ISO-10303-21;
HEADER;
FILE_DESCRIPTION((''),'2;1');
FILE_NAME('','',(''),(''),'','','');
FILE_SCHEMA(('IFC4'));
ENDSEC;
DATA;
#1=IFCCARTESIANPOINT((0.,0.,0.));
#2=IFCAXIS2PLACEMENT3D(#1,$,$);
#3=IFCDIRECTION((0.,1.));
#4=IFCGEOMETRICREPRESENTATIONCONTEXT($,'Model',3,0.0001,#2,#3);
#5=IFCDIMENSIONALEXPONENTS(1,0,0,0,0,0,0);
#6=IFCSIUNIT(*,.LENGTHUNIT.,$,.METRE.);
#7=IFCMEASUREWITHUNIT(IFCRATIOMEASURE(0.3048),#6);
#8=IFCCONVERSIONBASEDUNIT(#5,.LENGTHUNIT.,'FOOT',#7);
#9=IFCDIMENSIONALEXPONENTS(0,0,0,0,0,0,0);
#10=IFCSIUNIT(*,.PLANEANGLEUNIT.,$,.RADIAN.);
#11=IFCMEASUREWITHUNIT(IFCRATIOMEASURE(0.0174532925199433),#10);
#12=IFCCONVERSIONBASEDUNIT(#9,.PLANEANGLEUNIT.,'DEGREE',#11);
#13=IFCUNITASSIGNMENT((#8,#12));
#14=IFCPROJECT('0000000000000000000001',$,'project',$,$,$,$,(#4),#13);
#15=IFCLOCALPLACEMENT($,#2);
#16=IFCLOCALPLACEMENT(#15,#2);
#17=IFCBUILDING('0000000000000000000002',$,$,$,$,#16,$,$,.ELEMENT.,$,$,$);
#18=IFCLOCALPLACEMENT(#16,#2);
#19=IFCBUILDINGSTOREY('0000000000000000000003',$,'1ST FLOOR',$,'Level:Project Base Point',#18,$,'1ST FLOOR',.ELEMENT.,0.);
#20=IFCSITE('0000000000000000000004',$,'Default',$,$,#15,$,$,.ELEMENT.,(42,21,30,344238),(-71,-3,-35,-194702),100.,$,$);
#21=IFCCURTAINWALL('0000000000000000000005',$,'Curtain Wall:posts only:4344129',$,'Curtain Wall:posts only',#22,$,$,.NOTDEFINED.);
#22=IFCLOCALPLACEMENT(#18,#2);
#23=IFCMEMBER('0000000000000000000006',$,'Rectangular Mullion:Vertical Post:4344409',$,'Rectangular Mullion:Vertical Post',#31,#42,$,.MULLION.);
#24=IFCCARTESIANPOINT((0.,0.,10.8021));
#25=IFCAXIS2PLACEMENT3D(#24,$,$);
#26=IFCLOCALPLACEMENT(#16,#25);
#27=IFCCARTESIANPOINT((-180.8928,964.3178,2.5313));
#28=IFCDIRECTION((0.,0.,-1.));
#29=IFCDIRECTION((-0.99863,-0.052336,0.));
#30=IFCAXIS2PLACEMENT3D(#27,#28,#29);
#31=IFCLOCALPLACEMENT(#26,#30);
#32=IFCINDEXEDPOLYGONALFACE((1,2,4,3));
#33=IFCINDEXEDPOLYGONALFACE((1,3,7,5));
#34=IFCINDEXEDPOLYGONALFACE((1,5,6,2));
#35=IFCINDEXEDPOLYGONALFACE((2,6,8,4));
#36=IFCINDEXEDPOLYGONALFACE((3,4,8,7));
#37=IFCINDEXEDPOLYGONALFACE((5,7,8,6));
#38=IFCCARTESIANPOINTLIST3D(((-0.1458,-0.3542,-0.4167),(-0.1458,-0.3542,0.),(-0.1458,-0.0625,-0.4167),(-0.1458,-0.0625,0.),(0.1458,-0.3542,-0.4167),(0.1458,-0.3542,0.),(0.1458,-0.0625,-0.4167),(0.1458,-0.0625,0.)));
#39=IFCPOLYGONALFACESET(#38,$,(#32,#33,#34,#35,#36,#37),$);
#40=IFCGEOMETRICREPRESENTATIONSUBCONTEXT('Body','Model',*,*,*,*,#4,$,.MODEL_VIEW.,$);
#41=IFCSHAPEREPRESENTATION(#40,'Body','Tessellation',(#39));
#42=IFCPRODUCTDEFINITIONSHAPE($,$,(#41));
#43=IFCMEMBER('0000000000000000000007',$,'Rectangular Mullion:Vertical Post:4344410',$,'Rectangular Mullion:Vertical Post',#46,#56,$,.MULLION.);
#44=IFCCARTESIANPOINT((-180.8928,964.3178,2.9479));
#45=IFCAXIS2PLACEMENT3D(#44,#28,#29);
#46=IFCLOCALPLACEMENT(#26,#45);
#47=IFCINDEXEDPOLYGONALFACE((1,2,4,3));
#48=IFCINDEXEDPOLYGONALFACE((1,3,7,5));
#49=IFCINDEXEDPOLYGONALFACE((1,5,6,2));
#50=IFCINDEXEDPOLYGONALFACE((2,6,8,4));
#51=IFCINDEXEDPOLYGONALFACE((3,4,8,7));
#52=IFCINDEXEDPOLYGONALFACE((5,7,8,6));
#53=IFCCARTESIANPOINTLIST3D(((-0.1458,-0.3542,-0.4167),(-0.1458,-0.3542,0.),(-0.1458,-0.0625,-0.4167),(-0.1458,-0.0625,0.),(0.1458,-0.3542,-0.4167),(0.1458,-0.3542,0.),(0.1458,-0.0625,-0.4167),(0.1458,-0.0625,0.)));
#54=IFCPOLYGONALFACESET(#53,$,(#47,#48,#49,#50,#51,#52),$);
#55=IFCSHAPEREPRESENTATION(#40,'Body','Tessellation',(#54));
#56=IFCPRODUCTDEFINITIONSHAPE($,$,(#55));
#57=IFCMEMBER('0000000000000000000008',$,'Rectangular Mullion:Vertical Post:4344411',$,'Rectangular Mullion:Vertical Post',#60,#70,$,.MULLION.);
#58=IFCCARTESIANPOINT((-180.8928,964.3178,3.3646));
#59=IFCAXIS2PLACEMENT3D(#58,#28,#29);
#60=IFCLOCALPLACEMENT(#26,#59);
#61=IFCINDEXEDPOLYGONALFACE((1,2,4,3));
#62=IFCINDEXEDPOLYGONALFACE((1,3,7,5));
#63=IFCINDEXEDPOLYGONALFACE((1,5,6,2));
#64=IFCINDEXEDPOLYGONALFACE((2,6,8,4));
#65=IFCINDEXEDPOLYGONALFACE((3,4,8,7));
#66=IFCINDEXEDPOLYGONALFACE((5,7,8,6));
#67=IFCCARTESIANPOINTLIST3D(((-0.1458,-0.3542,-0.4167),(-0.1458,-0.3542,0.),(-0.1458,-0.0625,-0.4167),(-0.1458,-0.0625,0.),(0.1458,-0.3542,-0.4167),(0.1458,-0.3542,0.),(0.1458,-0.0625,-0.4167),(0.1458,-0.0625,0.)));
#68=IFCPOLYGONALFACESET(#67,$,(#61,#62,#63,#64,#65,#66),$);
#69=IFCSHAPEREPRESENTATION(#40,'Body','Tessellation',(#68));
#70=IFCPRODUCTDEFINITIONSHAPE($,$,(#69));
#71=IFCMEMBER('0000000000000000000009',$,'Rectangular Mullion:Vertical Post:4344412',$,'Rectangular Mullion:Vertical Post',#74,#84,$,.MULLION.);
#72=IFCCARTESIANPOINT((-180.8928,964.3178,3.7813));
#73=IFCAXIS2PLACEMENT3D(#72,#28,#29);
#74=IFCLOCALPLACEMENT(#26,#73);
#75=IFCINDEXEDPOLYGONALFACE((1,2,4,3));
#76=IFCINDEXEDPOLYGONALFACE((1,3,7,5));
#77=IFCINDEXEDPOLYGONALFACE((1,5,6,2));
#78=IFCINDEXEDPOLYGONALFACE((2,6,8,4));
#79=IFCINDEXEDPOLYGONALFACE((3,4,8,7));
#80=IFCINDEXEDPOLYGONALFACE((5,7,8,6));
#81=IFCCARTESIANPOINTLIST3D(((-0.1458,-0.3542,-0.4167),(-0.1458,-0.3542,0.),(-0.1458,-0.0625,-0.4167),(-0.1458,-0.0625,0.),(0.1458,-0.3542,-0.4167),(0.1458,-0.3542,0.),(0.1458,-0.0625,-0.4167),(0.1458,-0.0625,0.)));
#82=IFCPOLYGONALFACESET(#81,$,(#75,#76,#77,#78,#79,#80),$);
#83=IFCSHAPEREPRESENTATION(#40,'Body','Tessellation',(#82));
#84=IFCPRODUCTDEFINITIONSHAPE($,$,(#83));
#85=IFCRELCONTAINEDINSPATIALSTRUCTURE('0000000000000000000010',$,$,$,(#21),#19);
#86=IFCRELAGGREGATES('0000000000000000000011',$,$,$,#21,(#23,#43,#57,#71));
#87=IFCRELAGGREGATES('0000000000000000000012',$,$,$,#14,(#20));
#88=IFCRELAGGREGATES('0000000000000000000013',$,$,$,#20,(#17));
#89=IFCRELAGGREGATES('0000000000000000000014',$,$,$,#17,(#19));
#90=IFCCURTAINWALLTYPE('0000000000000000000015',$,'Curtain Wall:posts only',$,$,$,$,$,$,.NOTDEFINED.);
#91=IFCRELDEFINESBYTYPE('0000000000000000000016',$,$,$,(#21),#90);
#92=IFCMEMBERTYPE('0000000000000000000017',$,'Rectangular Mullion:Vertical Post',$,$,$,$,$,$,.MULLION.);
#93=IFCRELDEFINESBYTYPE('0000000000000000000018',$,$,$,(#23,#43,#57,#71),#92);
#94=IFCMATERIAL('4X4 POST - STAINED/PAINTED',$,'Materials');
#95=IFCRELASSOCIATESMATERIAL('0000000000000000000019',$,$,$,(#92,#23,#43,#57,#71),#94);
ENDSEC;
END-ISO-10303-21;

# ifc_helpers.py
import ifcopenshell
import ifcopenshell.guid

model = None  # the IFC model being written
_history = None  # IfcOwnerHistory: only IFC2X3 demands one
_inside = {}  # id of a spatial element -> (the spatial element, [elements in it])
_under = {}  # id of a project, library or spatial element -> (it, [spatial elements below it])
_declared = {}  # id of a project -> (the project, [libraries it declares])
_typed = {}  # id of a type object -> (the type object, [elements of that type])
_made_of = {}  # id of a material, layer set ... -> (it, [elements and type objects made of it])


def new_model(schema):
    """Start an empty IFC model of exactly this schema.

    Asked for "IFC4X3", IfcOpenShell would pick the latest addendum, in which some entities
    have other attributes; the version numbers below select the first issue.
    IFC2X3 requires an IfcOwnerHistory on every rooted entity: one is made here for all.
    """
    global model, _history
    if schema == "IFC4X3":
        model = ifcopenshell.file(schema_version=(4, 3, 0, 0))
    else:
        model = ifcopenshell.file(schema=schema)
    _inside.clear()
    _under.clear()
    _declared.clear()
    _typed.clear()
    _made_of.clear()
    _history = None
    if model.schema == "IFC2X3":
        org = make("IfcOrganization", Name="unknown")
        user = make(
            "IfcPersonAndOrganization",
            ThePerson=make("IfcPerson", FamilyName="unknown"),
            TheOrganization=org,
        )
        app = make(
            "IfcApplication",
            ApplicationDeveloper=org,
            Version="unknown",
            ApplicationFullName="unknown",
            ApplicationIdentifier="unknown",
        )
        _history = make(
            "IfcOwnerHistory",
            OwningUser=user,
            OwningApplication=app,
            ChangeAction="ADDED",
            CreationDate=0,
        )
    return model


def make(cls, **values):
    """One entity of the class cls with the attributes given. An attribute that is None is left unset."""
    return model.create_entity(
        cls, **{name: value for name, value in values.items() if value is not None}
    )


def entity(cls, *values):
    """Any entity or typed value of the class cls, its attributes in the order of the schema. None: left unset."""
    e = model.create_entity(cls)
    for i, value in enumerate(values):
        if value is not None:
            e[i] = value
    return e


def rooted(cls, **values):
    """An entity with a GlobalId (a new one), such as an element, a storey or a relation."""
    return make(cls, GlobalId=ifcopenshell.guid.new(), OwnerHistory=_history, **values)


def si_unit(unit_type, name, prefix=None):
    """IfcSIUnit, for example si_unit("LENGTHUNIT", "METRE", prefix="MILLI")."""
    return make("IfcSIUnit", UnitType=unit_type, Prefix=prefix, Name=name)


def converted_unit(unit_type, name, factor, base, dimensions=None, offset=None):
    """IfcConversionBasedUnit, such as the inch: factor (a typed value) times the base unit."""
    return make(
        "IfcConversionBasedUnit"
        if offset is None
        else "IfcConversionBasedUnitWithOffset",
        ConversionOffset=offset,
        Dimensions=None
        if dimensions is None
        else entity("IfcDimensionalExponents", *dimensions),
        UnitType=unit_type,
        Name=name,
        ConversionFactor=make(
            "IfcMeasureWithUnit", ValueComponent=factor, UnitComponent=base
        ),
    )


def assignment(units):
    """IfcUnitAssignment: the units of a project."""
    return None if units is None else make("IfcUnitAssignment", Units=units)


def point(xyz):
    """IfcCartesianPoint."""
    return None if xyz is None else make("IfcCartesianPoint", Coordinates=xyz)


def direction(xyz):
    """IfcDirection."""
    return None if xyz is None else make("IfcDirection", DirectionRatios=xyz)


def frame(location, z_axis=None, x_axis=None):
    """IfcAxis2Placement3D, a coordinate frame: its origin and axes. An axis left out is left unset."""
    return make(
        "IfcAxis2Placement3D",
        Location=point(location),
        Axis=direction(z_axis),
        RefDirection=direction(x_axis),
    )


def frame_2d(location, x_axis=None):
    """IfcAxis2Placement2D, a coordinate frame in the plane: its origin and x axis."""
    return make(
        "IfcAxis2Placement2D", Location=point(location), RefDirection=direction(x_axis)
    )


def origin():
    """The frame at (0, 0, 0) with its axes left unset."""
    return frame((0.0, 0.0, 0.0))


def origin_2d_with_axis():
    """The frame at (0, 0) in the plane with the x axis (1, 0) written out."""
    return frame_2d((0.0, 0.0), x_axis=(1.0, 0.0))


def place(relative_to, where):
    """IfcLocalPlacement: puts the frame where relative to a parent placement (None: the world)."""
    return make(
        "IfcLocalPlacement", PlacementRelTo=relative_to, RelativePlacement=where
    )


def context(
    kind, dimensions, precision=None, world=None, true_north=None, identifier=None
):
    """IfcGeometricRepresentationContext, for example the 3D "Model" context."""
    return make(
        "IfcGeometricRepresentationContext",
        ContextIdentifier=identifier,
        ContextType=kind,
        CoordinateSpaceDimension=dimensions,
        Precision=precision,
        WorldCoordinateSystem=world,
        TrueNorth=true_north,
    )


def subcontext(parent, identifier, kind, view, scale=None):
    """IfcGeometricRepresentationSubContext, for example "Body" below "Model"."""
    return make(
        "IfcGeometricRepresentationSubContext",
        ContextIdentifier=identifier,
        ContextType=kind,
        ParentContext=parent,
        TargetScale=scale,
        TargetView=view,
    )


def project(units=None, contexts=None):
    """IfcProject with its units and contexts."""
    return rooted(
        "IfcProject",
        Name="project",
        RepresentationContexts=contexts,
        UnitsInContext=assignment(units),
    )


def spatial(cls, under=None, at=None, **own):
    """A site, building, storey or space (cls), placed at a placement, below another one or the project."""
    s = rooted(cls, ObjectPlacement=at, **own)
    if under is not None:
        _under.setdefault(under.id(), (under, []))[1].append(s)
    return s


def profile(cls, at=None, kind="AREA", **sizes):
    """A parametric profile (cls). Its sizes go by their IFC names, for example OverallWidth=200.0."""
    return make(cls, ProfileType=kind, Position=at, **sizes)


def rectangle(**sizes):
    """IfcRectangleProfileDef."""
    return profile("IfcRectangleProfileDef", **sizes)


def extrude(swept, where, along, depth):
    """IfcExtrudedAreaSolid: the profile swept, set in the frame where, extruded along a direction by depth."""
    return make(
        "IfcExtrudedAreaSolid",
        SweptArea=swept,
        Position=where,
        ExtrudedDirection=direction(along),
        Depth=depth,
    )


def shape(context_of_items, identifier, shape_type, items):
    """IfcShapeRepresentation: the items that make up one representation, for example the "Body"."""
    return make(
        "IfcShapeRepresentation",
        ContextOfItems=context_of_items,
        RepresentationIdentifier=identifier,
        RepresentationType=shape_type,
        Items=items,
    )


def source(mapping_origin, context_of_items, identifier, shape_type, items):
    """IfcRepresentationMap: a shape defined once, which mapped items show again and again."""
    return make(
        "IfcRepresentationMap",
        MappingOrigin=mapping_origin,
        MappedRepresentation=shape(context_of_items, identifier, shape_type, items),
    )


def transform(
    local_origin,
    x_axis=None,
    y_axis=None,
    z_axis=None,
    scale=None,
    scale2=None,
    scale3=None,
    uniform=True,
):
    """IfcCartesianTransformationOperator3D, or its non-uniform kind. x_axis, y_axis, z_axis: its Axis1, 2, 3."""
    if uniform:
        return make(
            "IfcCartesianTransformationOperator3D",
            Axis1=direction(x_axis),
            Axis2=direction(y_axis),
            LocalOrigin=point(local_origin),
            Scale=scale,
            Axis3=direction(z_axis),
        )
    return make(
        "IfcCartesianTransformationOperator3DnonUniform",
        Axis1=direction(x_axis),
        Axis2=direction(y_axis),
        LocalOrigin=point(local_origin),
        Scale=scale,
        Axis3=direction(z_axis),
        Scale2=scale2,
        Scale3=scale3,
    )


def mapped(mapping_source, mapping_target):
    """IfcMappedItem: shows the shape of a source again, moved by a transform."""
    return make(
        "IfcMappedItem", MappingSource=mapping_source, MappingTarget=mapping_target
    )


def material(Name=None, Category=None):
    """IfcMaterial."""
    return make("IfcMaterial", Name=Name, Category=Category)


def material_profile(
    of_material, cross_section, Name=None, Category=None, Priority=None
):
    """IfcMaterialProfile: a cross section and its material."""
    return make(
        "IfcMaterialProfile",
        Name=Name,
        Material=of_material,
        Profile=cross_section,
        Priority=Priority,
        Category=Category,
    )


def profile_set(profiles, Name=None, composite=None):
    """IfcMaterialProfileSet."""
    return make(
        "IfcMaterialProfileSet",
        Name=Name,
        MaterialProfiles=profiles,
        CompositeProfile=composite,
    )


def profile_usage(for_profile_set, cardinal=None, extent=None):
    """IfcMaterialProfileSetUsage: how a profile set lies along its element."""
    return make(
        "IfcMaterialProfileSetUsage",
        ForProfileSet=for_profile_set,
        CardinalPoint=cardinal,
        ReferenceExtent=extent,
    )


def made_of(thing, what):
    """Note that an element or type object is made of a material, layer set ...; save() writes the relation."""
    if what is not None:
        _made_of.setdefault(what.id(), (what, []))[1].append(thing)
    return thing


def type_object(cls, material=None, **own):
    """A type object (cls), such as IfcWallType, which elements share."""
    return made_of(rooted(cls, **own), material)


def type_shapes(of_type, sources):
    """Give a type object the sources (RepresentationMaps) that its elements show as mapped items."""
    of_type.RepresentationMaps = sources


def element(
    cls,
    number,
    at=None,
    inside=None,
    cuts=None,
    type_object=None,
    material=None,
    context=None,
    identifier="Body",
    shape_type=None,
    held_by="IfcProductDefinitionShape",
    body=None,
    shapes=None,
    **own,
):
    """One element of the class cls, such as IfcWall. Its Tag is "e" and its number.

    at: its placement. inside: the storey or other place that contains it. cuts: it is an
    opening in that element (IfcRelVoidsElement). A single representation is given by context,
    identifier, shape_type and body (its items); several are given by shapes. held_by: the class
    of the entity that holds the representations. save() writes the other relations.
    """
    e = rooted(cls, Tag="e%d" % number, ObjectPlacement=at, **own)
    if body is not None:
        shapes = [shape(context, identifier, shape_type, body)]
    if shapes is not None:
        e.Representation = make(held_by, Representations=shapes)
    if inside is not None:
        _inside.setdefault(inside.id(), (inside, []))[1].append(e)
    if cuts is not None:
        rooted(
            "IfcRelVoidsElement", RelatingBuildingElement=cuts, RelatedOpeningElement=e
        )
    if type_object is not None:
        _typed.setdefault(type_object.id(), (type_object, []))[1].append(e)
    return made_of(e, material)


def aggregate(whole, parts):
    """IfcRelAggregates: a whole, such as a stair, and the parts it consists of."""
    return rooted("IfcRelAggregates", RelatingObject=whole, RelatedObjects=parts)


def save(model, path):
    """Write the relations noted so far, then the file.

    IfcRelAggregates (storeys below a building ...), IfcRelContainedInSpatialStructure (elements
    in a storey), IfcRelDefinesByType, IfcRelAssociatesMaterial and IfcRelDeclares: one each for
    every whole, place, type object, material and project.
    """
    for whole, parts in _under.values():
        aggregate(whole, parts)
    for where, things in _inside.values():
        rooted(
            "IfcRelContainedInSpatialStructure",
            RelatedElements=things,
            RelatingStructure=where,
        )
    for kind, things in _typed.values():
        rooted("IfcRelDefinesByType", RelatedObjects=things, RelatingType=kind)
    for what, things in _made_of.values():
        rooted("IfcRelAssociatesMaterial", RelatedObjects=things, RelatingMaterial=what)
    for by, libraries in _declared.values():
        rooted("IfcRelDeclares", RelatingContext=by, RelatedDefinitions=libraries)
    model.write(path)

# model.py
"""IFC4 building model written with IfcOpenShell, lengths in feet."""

from ifc_helpers import new_model, entity, si_unit, converted_unit, direction, frame, origin, origin_2d_with_axis, place, context, subcontext, project, spatial, rectangle, extrude, source, transform, mapped, material, material_profile, profile_set, profile_usage, type_object, type_shapes, element, aggregate, save


model = new_model("IFC4")

# Units and contexts
model_context = context("Model", 3, precision=0.0001, world=origin(), true_north=direction((0.0, 1.0)))
body_context = subcontext(model_context, "Body", "Model", "MODEL_VIEW")
ifc_project = project(units=[converted_unit("LENGTHUNIT", "FOOT", entity("IfcRatioMeasure", 0.3048), si_unit("LENGTHUNIT", "METRE"), dimensions=[1, 0, 0, 0, 0, 0, 0]), converted_unit("PLANEANGLEUNIT", "DEGREE", entity("IfcRatioMeasure", 0.0174532925199433), si_unit("PLANEANGLEUNIT", "RADIAN"), dimensions=[0, 0, 0, 0, 0, 0, 0])], contexts=[model_context])

# Site, building, storey
site_placement = place(None, origin())
site = spatial("IfcSite", under=ifc_project, at=site_placement, Name="Default", CompositionType="ELEMENT", RefLatitude=(42, 21, 30, 344238), RefLongitude=(-71, -3, -35, -194702), RefElevation=100.0)
building_placement = place(site_placement, origin())
building = spatial("IfcBuilding", under=site, at=building_placement, CompositionType="ELEMENT")
storey_placement = place(building_placement, origin())
storey = spatial("IfcBuildingStorey", under=building, at=storey_placement, Name="1ST FLOOR", ObjectType="Level:Project Base Point", LongName="1ST FLOOR", CompositionType="ELEMENT", Elevation=0.0)

# Curtain wall, members
curtain_wall_type_1 = type_object("IfcCurtainWallType", Name="Curtain Wall:posts only", PredefinedType="NOTDEFINED")
curtain_wall_1_placement = place(storey_placement, origin())
curtain_wall_1 = element("IfcCurtainWall", 1, at=curtain_wall_1_placement, inside=storey, type_object=curtain_wall_type_1, Name="Curtain Wall:posts only:4344129", ObjectType="Curtain Wall:posts only", PredefinedType="NOTDEFINED")
ifc_material_1 = material(Name="4X4 POST - STAINED/PAINTED", Category="Materials")
ifc_material_profile_1 = material_profile(ifc_material_1, rectangle(XDim=0.2917, YDim=0.2917, at=origin_2d_with_axis()), Name="Vertical Post")
ifc_profile_set_1 = profile_set([ifc_material_profile_1], Name="Vertical Post")
member_type_1 = type_object("IfcMemberType", Name="Rectangular Mullion:Vertical Post", PredefinedType="MULLION", material=ifc_profile_set_1)
shared_shape_1 = source(origin(), body_context, "Body", "SweptSolid", [
    extrude(rectangle(XDim=0.2917, YDim=0.2917, at=origin_2d_with_axis()), frame((0.0, -0.2083, -0.4167), z_axis=(0.0, 0.0, 1.0), x_axis=(0.0, -1.0, 0.0)), (0.0, 0.0, 1.0), 0.4167),
])
type_shapes(member_type_1, [shared_shape_1])
placement = place(building_placement, frame((0.0, 0.0, 10.8021)))
ifc_profile_usage_1 = profile_usage(ifc_profile_set_1)
member_1_placement = place(placement, frame((-180.8928, 964.3178, 2.5313), z_axis=(0.0, 0.0, -1.0), x_axis=(-0.99863, -0.052336, 0.0)))
member_1 = element("IfcMember", 2, at=member_1_placement, type_object=member_type_1, material=ifc_profile_usage_1, Name="Rectangular Mullion:Vertical Post:4344409", ObjectType="Rectangular Mullion:Vertical Post", PredefinedType="MULLION", context=body_context, shape_type="MappedRepresentation", body=[
    mapped(shared_shape_1, transform((0.0, 0.0, 0.0), scale=1.0)),
])
ifc_profile_usage_2 = profile_usage(ifc_profile_set_1)
member_2_placement = place(placement, frame((-180.8928, 964.3178, 2.9479), z_axis=(0.0, 0.0, -1.0), x_axis=(-0.99863, -0.052336, 0.0)))
member_2 = element("IfcMember", 3, at=member_2_placement, type_object=member_type_1, material=ifc_profile_usage_2, Name="Rectangular Mullion:Vertical Post:4344410", ObjectType="Rectangular Mullion:Vertical Post", PredefinedType="MULLION", context=body_context, shape_type="MappedRepresentation", body=[
    mapped(shared_shape_1, transform((0.0, 0.0, 0.0), scale=1.0)),
])
ifc_profile_usage_3 = profile_usage(ifc_profile_set_1)
member_3_placement = place(placement, frame((-180.8928, 964.3178, 3.3646), z_axis=(0.0, 0.0, -1.0), x_axis=(-0.99863, -0.052336, 0.0)))
member_3 = element("IfcMember", 4, at=member_3_placement, type_object=member_type_1, material=ifc_profile_usage_3, Name="Rectangular Mullion:Vertical Post:4344411", ObjectType="Rectangular Mullion:Vertical Post", PredefinedType="MULLION", context=body_context, shape_type="MappedRepresentation", body=[
    mapped(shared_shape_1, transform((0.0, 0.0, 0.0), scale=1.0)),
])
ifc_profile_usage_4 = profile_usage(ifc_profile_set_1)
member_4_placement = place(placement, frame((-180.8928, 964.3178, 3.7813), z_axis=(0.0, 0.0, -1.0), x_axis=(-0.99863, -0.052336, 0.0)))
member_4 = element("IfcMember", 5, at=member_4_placement, type_object=member_type_1, material=ifc_profile_usage_4, Name="Rectangular Mullion:Vertical Post:4344412", ObjectType="Rectangular Mullion:Vertical Post", PredefinedType="MULLION", context=body_context, shape_type="MappedRepresentation", body=[
    mapped(shared_shape_1, transform((0.0, 0.0, 0.0), scale=1.0)),
])
aggregate(curtain_wall_1, [member_1, member_2, member_3, member_4])

save(model, "model.ifc")
